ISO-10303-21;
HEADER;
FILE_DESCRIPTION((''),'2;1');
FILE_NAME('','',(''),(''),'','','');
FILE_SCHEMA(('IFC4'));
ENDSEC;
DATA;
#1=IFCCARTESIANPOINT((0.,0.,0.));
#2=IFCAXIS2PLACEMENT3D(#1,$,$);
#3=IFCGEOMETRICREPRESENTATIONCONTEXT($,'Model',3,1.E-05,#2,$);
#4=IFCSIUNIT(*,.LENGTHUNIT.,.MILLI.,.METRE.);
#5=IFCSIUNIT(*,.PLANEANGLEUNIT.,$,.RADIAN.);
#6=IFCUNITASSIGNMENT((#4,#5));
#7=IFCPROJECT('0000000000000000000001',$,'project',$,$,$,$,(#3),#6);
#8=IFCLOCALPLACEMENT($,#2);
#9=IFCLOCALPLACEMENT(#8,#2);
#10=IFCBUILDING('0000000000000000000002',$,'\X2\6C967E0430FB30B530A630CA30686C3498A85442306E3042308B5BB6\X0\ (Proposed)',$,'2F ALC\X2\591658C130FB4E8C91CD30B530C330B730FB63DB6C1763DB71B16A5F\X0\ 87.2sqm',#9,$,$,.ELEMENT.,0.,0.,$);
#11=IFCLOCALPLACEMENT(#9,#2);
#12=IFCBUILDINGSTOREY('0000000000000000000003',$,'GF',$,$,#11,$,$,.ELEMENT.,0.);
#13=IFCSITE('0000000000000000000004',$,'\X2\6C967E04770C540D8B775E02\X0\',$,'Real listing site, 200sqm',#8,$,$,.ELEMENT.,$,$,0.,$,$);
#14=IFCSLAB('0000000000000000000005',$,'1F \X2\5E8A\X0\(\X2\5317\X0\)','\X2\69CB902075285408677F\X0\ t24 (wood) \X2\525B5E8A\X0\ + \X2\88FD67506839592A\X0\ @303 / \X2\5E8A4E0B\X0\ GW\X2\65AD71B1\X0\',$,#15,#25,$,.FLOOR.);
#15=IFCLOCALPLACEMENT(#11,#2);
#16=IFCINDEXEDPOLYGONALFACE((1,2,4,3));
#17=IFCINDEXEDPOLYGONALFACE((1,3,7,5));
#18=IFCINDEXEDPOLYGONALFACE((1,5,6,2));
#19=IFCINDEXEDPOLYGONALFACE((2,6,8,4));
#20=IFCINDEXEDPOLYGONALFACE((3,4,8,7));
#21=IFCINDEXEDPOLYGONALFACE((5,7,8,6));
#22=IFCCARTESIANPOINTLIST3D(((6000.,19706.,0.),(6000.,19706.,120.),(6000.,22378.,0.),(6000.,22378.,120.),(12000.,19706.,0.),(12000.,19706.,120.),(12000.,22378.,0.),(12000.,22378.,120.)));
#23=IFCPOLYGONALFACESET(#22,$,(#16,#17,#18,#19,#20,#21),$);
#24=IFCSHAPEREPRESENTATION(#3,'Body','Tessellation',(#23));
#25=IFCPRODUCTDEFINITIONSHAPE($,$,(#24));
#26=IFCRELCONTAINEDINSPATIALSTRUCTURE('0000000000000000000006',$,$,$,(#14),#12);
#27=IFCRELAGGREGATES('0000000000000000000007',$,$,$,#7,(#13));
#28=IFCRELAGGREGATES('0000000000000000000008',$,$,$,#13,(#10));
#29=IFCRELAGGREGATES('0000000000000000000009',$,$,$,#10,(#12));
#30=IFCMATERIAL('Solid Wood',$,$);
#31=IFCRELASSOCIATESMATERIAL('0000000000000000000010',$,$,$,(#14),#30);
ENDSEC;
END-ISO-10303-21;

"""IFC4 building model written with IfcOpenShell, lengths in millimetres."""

from ifc_helpers import new_model, si_unit, frame, frame_2d, origin, place, context, project, spatial, rectangle, extrude, material, element, save


model = new_model("IFC4")

# Units and contexts
model_context = context("Model", 3, precision=1e-05, world=origin())
ifc_project = project(units=[si_unit("LENGTHUNIT", "METRE", prefix="MILLI"), si_unit("PLANEANGLEUNIT", "RADIAN")], contexts=[model_context])

# Site, building, storey
site_placement = place(None, origin())
site = spatial("IfcSite", under=ifc_project, at=site_placement, Name="沖縄県名護市", ObjectType="Real listing site, 200sqm", CompositionType="ELEMENT", RefElevation=0.0)
building_placement = place(site_placement, origin())
building = spatial("IfcBuilding", under=site, at=building_placement, Name="沖縄・サウナと水風呂のある家 (Proposed)", ObjectType="2F ALC外壁・二重サッシ・換気換熱機 87.2sqm", CompositionType="ELEMENT", ElevationOfRefHeight=0.0, ElevationOfTerrain=0.0)
storey_placement = place(building_placement, origin())
storey = spatial("IfcBuildingStorey", under=building, at=storey_placement, Name="GF", CompositionType="ELEMENT", Elevation=0.0)

# Shared definitions
ifc_material_1 = material(Name="Solid Wood")

# Slab
slab_placement = place(storey_placement, frame((3000.0, 9853.0, 0.0)))
element("IfcSlab", 1, at=slab_placement, inside=storey, material=ifc_material_1, Name="1F 床(北)", Description="構造用合板 t24 (wood) 剛床 + 製材根太 @303 / 床下 GW断熱", PredefinedType="FLOOR", context=model_context, shape_type="SweptSolid", body=[
    extrude(rectangle(XDim=6000.0, YDim=2672.0, at=frame_2d((3000.0, 1336.0))), frame((3000.0, 9853.0, 0.0)), (0.0, 0.0, 1.0), 120.0),
])

save(model, "model.ifc")
